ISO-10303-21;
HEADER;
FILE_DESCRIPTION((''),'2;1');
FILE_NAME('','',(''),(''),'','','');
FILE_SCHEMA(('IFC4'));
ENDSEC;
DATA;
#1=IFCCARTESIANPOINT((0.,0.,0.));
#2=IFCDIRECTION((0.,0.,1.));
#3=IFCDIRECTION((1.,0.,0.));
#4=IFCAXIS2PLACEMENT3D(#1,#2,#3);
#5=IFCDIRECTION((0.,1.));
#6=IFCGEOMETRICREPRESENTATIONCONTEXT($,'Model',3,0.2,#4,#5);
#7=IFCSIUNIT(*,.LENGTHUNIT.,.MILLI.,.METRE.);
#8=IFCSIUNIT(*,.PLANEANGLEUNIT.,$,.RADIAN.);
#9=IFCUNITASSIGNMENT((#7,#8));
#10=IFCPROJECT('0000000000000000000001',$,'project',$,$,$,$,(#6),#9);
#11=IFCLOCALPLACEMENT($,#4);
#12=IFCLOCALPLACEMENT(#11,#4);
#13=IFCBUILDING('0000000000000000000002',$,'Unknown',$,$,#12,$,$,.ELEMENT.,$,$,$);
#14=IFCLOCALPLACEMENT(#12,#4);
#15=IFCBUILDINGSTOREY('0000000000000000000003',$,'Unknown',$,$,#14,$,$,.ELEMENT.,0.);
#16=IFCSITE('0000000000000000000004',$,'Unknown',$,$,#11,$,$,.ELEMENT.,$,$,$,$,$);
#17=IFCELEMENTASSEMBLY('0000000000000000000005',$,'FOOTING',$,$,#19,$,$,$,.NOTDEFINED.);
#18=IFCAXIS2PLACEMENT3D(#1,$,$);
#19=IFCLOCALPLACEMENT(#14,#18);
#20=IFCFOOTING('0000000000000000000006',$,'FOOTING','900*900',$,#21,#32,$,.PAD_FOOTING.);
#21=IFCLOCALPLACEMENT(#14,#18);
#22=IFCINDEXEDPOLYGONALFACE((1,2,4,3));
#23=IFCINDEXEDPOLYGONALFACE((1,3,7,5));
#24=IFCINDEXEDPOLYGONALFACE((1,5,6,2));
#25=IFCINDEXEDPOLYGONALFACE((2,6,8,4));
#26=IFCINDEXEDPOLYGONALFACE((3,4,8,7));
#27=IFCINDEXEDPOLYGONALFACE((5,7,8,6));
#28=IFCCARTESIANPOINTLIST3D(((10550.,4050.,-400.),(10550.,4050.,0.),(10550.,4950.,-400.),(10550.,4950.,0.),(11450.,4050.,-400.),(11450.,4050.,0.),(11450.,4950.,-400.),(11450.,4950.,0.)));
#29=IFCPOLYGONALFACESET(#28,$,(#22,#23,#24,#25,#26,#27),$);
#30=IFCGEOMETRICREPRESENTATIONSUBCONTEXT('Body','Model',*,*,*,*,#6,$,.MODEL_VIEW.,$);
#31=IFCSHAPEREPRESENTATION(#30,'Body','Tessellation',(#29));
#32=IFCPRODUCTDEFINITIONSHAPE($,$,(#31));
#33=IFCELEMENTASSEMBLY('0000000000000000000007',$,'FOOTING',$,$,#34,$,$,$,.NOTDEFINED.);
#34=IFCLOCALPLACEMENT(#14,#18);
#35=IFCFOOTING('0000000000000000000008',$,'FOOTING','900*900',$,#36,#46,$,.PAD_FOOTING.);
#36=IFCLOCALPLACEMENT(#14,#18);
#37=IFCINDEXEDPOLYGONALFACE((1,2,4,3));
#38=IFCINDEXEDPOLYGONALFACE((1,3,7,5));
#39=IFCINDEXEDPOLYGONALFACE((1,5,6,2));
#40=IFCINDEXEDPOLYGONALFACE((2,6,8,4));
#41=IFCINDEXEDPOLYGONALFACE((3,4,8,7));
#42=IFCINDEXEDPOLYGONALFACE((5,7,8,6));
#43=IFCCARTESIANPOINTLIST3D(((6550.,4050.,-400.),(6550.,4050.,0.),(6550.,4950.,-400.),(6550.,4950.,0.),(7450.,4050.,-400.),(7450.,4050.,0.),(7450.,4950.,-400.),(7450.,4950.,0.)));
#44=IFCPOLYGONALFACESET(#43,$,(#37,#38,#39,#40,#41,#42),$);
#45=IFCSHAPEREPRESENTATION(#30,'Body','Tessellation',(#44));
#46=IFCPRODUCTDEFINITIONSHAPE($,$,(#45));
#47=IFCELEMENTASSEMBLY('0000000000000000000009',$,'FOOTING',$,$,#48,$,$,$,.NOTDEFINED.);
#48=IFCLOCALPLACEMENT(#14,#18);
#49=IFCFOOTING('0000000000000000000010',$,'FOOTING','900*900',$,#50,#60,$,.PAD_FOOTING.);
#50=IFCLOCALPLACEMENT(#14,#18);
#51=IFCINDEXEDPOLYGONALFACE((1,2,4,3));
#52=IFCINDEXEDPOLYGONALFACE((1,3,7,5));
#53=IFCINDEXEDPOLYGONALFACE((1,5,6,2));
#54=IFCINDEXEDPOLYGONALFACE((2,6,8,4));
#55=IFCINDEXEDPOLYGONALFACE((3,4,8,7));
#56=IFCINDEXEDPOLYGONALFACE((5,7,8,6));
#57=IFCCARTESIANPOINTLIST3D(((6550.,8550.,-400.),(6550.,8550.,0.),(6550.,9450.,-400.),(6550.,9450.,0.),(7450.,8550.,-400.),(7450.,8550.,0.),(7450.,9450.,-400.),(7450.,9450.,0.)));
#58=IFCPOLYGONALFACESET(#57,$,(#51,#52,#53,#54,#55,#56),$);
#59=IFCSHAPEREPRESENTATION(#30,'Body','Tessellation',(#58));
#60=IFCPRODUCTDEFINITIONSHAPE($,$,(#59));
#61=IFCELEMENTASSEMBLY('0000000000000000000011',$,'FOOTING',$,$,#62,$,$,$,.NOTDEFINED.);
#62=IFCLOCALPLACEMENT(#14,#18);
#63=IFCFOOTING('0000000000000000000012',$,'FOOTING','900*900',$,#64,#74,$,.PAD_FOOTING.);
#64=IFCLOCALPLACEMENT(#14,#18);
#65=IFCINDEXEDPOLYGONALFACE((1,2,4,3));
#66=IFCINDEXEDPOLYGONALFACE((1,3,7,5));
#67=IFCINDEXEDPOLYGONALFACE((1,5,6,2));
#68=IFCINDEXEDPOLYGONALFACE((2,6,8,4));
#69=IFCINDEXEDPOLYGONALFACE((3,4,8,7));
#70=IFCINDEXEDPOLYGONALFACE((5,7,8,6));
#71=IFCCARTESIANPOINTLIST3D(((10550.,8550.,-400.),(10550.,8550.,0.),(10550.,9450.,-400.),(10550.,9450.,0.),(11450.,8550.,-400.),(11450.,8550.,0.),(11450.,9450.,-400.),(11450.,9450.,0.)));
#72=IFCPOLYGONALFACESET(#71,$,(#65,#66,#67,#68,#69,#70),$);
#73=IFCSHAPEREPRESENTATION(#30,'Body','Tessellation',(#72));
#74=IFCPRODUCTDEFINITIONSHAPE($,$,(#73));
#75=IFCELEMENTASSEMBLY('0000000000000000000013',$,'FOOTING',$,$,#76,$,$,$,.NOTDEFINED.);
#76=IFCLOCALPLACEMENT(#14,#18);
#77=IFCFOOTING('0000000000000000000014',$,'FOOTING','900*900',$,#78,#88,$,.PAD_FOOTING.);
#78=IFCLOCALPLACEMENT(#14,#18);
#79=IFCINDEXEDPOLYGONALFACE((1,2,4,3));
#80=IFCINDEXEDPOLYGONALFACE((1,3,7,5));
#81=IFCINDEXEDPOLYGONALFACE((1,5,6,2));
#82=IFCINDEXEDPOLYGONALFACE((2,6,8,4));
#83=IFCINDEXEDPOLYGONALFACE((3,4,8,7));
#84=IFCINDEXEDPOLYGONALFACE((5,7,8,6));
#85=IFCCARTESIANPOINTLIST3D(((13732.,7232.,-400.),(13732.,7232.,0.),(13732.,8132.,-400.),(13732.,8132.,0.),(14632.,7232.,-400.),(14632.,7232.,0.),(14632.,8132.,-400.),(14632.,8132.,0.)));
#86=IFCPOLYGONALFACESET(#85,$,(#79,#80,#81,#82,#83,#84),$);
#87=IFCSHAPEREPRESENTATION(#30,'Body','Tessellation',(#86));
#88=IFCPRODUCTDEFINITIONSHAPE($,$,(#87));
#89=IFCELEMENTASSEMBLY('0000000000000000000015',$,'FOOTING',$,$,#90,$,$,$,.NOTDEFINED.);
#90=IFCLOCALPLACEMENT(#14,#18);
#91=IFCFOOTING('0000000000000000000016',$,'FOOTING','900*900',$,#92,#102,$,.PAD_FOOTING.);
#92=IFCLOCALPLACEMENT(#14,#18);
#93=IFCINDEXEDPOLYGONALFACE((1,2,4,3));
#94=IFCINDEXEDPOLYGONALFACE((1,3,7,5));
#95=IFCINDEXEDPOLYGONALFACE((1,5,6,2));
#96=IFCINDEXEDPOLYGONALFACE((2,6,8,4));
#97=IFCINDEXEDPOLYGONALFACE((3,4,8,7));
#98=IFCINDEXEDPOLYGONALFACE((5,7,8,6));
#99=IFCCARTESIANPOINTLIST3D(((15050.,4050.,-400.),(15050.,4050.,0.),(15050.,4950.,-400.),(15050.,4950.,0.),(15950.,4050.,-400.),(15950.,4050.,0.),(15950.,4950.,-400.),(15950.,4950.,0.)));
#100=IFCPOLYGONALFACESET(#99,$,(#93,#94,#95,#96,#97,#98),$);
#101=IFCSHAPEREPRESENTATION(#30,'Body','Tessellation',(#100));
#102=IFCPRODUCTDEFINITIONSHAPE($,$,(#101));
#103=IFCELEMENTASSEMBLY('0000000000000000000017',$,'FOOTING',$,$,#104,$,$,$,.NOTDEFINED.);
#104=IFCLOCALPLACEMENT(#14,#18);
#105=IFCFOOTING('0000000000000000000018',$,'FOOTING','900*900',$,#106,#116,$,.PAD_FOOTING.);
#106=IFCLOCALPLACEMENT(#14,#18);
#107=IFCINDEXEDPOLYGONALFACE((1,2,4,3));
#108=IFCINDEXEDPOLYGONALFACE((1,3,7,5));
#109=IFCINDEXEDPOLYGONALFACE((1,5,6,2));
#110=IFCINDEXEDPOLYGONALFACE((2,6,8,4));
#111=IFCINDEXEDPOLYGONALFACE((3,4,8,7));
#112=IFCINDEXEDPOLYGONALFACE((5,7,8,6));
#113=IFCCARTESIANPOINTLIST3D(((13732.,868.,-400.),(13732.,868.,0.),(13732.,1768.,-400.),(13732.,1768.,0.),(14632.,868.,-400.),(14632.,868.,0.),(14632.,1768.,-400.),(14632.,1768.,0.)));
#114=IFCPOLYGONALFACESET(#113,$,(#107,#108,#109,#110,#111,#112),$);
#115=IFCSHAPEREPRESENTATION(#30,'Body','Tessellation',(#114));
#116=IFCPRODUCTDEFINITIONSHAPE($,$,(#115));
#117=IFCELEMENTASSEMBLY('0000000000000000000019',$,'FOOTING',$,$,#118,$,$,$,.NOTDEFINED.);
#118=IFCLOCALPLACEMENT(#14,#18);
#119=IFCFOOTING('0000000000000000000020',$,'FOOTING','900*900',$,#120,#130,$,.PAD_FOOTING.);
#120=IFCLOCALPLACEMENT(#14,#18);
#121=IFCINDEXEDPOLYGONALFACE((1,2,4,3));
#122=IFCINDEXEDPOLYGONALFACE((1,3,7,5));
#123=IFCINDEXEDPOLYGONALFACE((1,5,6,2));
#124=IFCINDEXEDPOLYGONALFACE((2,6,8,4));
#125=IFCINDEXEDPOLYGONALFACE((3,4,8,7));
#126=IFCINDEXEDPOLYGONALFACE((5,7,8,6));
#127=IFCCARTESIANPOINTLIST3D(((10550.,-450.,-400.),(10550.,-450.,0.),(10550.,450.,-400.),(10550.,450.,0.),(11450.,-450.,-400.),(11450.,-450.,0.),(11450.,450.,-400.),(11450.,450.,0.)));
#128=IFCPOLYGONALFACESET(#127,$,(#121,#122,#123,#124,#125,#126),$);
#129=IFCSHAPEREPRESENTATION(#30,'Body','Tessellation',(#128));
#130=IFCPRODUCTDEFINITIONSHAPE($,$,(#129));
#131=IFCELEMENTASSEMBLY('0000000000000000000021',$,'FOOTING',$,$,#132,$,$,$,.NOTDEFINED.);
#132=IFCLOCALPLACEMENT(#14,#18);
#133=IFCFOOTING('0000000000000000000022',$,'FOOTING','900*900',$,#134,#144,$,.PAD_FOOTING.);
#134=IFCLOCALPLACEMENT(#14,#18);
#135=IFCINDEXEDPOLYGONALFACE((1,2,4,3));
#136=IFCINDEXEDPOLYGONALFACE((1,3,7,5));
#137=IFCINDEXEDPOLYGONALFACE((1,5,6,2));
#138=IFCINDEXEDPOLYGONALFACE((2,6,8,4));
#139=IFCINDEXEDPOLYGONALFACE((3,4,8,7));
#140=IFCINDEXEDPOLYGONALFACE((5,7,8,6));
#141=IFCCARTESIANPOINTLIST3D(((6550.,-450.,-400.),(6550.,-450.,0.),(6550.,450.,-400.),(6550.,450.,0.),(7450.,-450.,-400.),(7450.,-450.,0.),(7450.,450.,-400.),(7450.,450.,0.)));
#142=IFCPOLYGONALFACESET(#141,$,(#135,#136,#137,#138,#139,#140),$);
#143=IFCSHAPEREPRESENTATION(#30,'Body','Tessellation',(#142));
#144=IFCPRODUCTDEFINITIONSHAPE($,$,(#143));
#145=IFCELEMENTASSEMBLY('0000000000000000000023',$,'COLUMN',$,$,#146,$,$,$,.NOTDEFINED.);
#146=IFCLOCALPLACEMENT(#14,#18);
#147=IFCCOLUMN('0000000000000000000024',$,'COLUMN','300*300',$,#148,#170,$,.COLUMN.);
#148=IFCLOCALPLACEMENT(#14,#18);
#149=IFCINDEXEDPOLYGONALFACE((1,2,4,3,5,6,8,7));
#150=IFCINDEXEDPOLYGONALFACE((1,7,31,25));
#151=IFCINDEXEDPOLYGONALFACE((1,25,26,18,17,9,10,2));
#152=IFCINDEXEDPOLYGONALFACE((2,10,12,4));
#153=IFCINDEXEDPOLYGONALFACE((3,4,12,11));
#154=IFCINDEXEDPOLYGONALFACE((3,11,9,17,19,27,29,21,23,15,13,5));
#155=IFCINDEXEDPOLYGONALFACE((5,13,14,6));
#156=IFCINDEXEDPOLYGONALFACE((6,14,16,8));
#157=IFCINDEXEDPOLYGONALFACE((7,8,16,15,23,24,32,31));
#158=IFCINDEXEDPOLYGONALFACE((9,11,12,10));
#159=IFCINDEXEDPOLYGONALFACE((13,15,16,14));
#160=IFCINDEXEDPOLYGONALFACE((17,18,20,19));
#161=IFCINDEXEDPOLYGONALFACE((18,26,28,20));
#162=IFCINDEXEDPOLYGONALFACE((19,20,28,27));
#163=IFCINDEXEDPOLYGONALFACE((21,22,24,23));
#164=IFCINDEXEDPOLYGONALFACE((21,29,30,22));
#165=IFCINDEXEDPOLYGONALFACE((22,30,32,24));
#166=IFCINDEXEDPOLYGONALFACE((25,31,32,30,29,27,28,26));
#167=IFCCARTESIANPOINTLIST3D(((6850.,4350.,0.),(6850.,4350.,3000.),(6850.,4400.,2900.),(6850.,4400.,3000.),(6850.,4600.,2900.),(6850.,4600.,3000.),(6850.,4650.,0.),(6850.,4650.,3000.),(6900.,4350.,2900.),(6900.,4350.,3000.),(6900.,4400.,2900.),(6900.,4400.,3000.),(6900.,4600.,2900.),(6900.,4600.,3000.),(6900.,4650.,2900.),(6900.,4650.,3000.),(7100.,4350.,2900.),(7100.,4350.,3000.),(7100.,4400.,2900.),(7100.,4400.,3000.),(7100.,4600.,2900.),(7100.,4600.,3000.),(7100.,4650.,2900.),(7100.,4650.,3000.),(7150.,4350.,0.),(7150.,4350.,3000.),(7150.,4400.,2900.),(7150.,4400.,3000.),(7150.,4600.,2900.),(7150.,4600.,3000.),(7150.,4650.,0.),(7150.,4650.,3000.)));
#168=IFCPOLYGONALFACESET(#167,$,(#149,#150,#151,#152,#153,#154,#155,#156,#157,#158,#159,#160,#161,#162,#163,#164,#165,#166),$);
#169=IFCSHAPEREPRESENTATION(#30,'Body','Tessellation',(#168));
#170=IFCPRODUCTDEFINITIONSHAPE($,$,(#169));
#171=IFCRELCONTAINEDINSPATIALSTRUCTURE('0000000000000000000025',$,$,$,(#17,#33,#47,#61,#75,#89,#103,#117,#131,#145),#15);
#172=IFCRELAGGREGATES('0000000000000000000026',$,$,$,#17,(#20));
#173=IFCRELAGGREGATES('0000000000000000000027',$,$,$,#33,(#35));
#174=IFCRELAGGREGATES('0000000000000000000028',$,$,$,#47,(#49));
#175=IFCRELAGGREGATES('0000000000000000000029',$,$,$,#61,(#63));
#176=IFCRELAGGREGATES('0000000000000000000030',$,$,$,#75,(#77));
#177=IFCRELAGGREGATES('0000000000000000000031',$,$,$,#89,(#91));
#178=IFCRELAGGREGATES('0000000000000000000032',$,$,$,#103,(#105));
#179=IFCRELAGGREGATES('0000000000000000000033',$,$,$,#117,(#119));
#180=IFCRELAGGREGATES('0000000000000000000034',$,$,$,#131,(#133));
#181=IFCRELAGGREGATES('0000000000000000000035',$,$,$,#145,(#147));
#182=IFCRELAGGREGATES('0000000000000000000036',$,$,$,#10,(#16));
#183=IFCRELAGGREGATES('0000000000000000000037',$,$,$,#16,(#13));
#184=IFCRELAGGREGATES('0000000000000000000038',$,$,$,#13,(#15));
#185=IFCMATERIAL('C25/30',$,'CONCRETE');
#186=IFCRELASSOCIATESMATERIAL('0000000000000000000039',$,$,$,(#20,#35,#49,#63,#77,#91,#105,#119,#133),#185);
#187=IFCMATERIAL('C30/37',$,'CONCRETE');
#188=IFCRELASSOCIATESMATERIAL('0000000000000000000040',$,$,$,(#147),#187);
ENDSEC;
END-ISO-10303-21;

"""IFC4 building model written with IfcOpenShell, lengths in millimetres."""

from ifc_helpers import new_model, si_unit, direction, frame, origin_with_axes, place, context, subcontext, project, spatial, line, indexed_curve, outline, extrude, material, element, aggregate, save


model = new_model("IFC4")

# Units and contexts
model_context = context("Model", 3, precision=0.2, world=origin_with_axes(), true_north=direction((0.0, 1.0)))
body_context = subcontext(model_context, "Body", "Model", "MODEL_VIEW")
ifc_project = project(units=[si_unit("LENGTHUNIT", "METRE", prefix="MILLI"), si_unit("PLANEANGLEUNIT", "RADIAN")], contexts=[model_context])

# Site, building, storey
site_placement = place(None, origin_with_axes())
site = spatial("IfcSite", under=ifc_project, at=site_placement, Name="Unknown", CompositionType="ELEMENT")
building_placement = place(site_placement, origin_with_axes())
building = spatial("IfcBuilding", under=site, at=building_placement, Name="Unknown", CompositionType="ELEMENT")
storey_placement = place(building_placement, origin_with_axes())
storey = spatial("IfcBuildingStorey", under=building, at=storey_placement, Name="Unknown", CompositionType="ELEMENT", Elevation=0.0)

# Element assemblies, footings
assembly_1_placement = place(storey_placement, frame((11000.0, 4500.0, -400.0), z_axis=(-1.0, 0.0, 0.0), x_axis=(0.0, 0.0, 1.0)))
assembly_1 = element("IfcElementAssembly", 1, at=assembly_1_placement, inside=storey, Name="FOOTING", PredefinedType="NOTDEFINED")
ifc_material_1 = material(Name="C25/30", Category="CONCRETE")
footing_1_placement = place(assembly_1_placement, origin_with_axes())
footing_1 = element("IfcFooting", 2, at=footing_1_placement, material=ifc_material_1, Name="FOOTING", Description="900*900", PredefinedType="PAD_FOOTING", context=body_context, shape_type="SolidModel", body=[
    extrude(outline(indexed_curve([(-450.0, -450.0), (450.0, -450.0), (450.0, 450.0), (-450.0, 450.0)], segments=[line(1, 2, 3, 4, 1)])), frame((0.0, 0.0, 0.0), z_axis=(-1.0, 0.0, 0.0), x_axis=(0.0, 0.0, 1.0)), (0.0, 0.0, -1.0), 400.0),
])
aggregate(assembly_1, [footing_1])
assembly_2_placement = place(storey_placement, frame((7000.0, 4500.0, -400.0), z_axis=(-1.0, 0.0, 0.0), x_axis=(0.0, 0.0, 1.0)))
assembly_2 = element("IfcElementAssembly", 3, at=assembly_2_placement, inside=storey, Name="FOOTING", PredefinedType="NOTDEFINED")
footing_2_placement = place(assembly_2_placement, origin_with_axes())
footing_2 = element("IfcFooting", 4, at=footing_2_placement, material=ifc_material_1, Name="FOOTING", Description="900*900", PredefinedType="PAD_FOOTING", context=body_context, shape_type="SolidModel", body=[
    extrude(outline(indexed_curve([(-450.0, -450.0), (450.0, -450.0), (450.0, 450.0), (-450.0, 450.0)], segments=[line(1, 2, 3, 4, 1)])), frame((0.0, 0.0, 0.0), z_axis=(-1.0, 0.0, 0.0), x_axis=(0.0, 0.0, 1.0)), (0.0, 0.0, -1.0), 400.0),
])
aggregate(assembly_2, [footing_2])
assembly_3_placement = place(storey_placement, frame((7000.0, 9000.0, -400.0), z_axis=(-1.0, 0.0, 0.0), x_axis=(0.0, 0.0, 1.0)))
assembly_3 = element("IfcElementAssembly", 5, at=assembly_3_placement, inside=storey, Name="FOOTING", PredefinedType="NOTDEFINED")
footing_3_placement = place(assembly_3_placement, origin_with_axes())
footing_3 = element("IfcFooting", 6, at=footing_3_placement, material=ifc_material_1, Name="FOOTING", Description="900*900", PredefinedType="PAD_FOOTING", context=body_context, shape_type="SolidModel", body=[
    extrude(outline(indexed_curve([(-450.0, -450.0), (450.0, -450.0), (450.0, 450.0), (-450.0, 450.0)], segments=[line(1, 2, 3, 4, 1)])), frame((0.0, 0.0, 0.0), z_axis=(-1.0, 0.0, 0.0), x_axis=(0.0, 0.0, 1.0)), (0.0, 0.0, -1.0), 400.0),
])
aggregate(assembly_3, [footing_3])
assembly_4_placement = place(storey_placement, frame((11000.0, 9000.0, -400.0), z_axis=(-1.0, 0.0, 0.0), x_axis=(0.0, 0.0, 1.0)))
assembly_4 = element("IfcElementAssembly", 7, at=assembly_4_placement, inside=storey, Name="FOOTING", PredefinedType="NOTDEFINED")
footing_4_placement = place(assembly_4_placement, origin_with_axes())
footing_4 = element("IfcFooting", 8, at=footing_4_placement, material=ifc_material_1, Name="FOOTING", Description="900*900", PredefinedType="PAD_FOOTING", context=body_context, shape_type="SolidModel", body=[
    extrude(outline(indexed_curve([(-450.0, -450.0), (450.0, -450.0), (450.0, 450.0), (-450.0, 450.0)], segments=[line(1, 2, 3, 4, 1)])), frame((0.0, 0.0, 0.0), z_axis=(-1.0, 0.0, 0.0), x_axis=(0.0, 0.0, 1.0)), (0.0, 0.0, -1.0), 400.0),
])
aggregate(assembly_4, [footing_4])
assembly_5_placement = place(storey_placement, frame((14182.0, 7682.0, -400.0), z_axis=(-1.0, 0.0, 0.0), x_axis=(0.0, 0.0, 1.0)))
assembly_5 = element("IfcElementAssembly", 9, at=assembly_5_placement, inside=storey, Name="FOOTING", PredefinedType="NOTDEFINED")
footing_5_placement = place(assembly_5_placement, origin_with_axes())
footing_5 = element("IfcFooting", 10, at=footing_5_placement, material=ifc_material_1, Name="FOOTING", Description="900*900", PredefinedType="PAD_FOOTING", context=body_context, shape_type="SolidModel", body=[
    extrude(outline(indexed_curve([(-450.0, -450.0), (450.0, -450.0), (450.0, 450.0), (-450.0, 450.0)], segments=[line(1, 2, 3, 4, 1)])), frame((0.0, 0.0, 0.0), z_axis=(-1.0, 0.0, 0.0), x_axis=(0.0, 0.0, 1.0)), (0.0, 0.0, -1.0), 400.0),
])
aggregate(assembly_5, [footing_5])
assembly_6_placement = place(storey_placement, frame((15500.0, 4500.0, -400.0), z_axis=(-1.0, 0.0, 0.0), x_axis=(0.0, 0.0, 1.0)))
assembly_6 = element("IfcElementAssembly", 11, at=assembly_6_placement, inside=storey, Name="FOOTING", PredefinedType="NOTDEFINED")
footing_6_placement = place(assembly_6_placement, origin_with_axes())
footing_6 = element("IfcFooting", 12, at=footing_6_placement, material=ifc_material_1, Name="FOOTING", Description="900*900", PredefinedType="PAD_FOOTING", context=body_context, shape_type="SolidModel", body=[
    extrude(outline(indexed_curve([(-450.0, -450.0), (450.0, -450.0), (450.0, 450.0), (-450.0, 450.0)], segments=[line(1, 2, 3, 4, 1)])), frame((0.0, 0.0, 0.0), z_axis=(-1.0, 0.0, 0.0), x_axis=(0.0, 0.0, 1.0)), (0.0, 0.0, -1.0), 400.0),
])
aggregate(assembly_6, [footing_6])
assembly_7_placement = place(storey_placement, frame((14182.0, 1318.0, -400.0), z_axis=(-1.0, 0.0, 0.0), x_axis=(0.0, 0.0, 1.0)))
assembly_7 = element("IfcElementAssembly", 13, at=assembly_7_placement, inside=storey, Name="FOOTING", PredefinedType="NOTDEFINED")
footing_7_placement = place(assembly_7_placement, origin_with_axes())
footing_7 = element("IfcFooting", 14, at=footing_7_placement, material=ifc_material_1, Name="FOOTING", Description="900*900", PredefinedType="PAD_FOOTING", context=body_context, shape_type="SolidModel", body=[
    extrude(outline(indexed_curve([(-450.0, -450.0), (450.0, -450.0), (450.0, 450.0), (-450.0, 450.0)], segments=[line(1, 2, 3, 4, 1)])), frame((0.0, 0.0, 0.0), z_axis=(-1.0, 0.0, 0.0), x_axis=(0.0, 0.0, 1.0)), (0.0, 0.0, -1.0), 400.0),
])
aggregate(assembly_7, [footing_7])
assembly_8_placement = place(storey_placement, frame((11000.0, 0.0, -400.0), z_axis=(-1.0, 0.0, 0.0), x_axis=(0.0, 0.0, 1.0)))
assembly_8 = element("IfcElementAssembly", 15, at=assembly_8_placement, inside=storey, Name="FOOTING", PredefinedType="NOTDEFINED")
footing_8_placement = place(assembly_8_placement, origin_with_axes())
footing_8 = element("IfcFooting", 16, at=footing_8_placement, material=ifc_material_1, Name="FOOTING", Description="900*900", PredefinedType="PAD_FOOTING", context=body_context, shape_type="SolidModel", body=[
    extrude(outline(indexed_curve([(-450.0, -450.0), (450.0, -450.0), (450.0, 450.0), (-450.0, 450.0)], segments=[line(1, 2, 3, 4, 1)])), frame((0.0, 0.0, 0.0), z_axis=(-1.0, 0.0, 0.0), x_axis=(0.0, 0.0, 1.0)), (0.0, 0.0, -1.0), 400.0),
])
aggregate(assembly_8, [footing_8])
assembly_9_placement = place(storey_placement, frame((7000.0, 0.0, -400.0), z_axis=(-1.0, 0.0, 0.0), x_axis=(0.0, 0.0, 1.0)))
assembly_9 = element("IfcElementAssembly", 17, at=assembly_9_placement, inside=storey, Name="FOOTING", PredefinedType="NOTDEFINED")
footing_9_placement = place(assembly_9_placement, origin_with_axes())
footing_9 = element("IfcFooting", 18, at=footing_9_placement, material=ifc_material_1, Name="FOOTING", Description="900*900", PredefinedType="PAD_FOOTING", context=body_context, shape_type="SolidModel", body=[
    extrude(outline(indexed_curve([(-450.0, -450.0), (450.0, -450.0), (450.0, 450.0), (-450.0, 450.0)], segments=[line(1, 2, 3, 4, 1)])), frame((0.0, 0.0, 0.0), z_axis=(-1.0, 0.0, 0.0), x_axis=(0.0, 0.0, 1.0)), (0.0, 0.0, -1.0), 400.0),
])
aggregate(assembly_9, [footing_9])

# Element assembly, column, voiding features
ifc_material_2 = material(Name="C30/37", Category="CONCRETE")
assembly_10_placement = place(storey_placement, frame((7000.0, 4500.0, 0.0), z_axis=(-1.0, 0.0, 0.0), x_axis=(0.0, 0.0, 1.0)))
assembly_10 = element("IfcElementAssembly", 19, at=assembly_10_placement, inside=storey, Name="COLUMN", PredefinedType="NOTDEFINED")
column_1_placement = place(assembly_10_placement, origin_with_axes())
column_1 = element("IfcColumn", 20, at=column_1_placement, material=ifc_material_2, Name="COLUMN", Description="300*300", PredefinedType="COLUMN", context=body_context, shape_type="SolidModel", body=[
    extrude(outline(indexed_curve([(-150.0, -150.0), (150.0, -150.0), (150.0, 150.0), (-150.0, 150.0)], segments=[line(1, 2, 3, 4, 1)])), frame((0.0, 0.0, 0.0), z_axis=(-1.0, 0.0, 0.0), x_axis=(0.0, 0.0, 1.0)), (0.0, 0.0, -1.0), 3200.0),
])
voiding_feature_1_placement = place(column_1_placement, frame((3100.0, -4650.0, 7150.0), z_axis=(1.0, 0.0, 0.0), x_axis=(0.0, 0.0, -1.0)))
element("IfcVoidingFeature", 21, at=voiding_feature_1_placement, cuts=column_1, Name="SLAB", PredefinedType="HOLE", context=body_context, shape_type="SolidModel", body=[
    extrude(outline(indexed_curve([(0.0, 0.0), (11300.0, 0.0), (11300.0, 9300.0), (0.0, 9300.0)], segments=[line(1, 2, 3, 4, 1)])), frame((0.0, 0.0, 100.0), z_axis=(0.0, 0.0, 1.0), x_axis=(1.0, 0.0, 0.0)), (0.0, 0.0, -1.0), 200.0),
])
voiding_feature_2_placement = place(column_1_placement, frame((3050.0, 4350.0, 0.0), z_axis=(0.0, 0.0, 1.0), x_axis=(0.0, -1.0, 0.0)))
element("IfcVoidingFeature", 22, at=voiding_feature_2_placement, cuts=column_1, Name="BEAM", PredefinedType="HOLE", context=body_context, shape_type="SolidModel", body=[
    extrude(outline(indexed_curve([(-100.0, -150.0), (100.0, -150.0), (100.0, 150.0), (-100.0, 150.0)], segments=[line(1, 2, 3, 4, 1)])), frame((0.0, 0.0, 0.0), z_axis=(-1.0, 0.0, 0.0), x_axis=(0.0, 0.0, 1.0)), (0.0, 0.0, -1.0), 8700.0),
])
voiding_feature_3_placement = place(column_1_placement, frame((3050.0, 0.0, 6850.0), z_axis=(0.0, -1.0, 0.0), x_axis=(0.0, 0.0, -1.0)))
element("IfcVoidingFeature", 23, at=voiding_feature_3_placement, cuts=column_1, Name="BEAM", PredefinedType="HOLE", context=body_context, shape_type="SolidModel", body=[
    extrude(outline(indexed_curve([(-100.0, -150.0), (100.0, -150.0), (100.0, 150.0), (-100.0, 150.0)], segments=[line(1, 2, 3, 4, 1)])), frame((0.0, 0.0, 0.0), z_axis=(-1.0, 0.0, 0.0), x_axis=(0.0, 0.0, 1.0)), (0.0, 0.0, -1.0), 10750.0),
])
aggregate(assembly_10, [column_1])

save(model, "model.ifc")
